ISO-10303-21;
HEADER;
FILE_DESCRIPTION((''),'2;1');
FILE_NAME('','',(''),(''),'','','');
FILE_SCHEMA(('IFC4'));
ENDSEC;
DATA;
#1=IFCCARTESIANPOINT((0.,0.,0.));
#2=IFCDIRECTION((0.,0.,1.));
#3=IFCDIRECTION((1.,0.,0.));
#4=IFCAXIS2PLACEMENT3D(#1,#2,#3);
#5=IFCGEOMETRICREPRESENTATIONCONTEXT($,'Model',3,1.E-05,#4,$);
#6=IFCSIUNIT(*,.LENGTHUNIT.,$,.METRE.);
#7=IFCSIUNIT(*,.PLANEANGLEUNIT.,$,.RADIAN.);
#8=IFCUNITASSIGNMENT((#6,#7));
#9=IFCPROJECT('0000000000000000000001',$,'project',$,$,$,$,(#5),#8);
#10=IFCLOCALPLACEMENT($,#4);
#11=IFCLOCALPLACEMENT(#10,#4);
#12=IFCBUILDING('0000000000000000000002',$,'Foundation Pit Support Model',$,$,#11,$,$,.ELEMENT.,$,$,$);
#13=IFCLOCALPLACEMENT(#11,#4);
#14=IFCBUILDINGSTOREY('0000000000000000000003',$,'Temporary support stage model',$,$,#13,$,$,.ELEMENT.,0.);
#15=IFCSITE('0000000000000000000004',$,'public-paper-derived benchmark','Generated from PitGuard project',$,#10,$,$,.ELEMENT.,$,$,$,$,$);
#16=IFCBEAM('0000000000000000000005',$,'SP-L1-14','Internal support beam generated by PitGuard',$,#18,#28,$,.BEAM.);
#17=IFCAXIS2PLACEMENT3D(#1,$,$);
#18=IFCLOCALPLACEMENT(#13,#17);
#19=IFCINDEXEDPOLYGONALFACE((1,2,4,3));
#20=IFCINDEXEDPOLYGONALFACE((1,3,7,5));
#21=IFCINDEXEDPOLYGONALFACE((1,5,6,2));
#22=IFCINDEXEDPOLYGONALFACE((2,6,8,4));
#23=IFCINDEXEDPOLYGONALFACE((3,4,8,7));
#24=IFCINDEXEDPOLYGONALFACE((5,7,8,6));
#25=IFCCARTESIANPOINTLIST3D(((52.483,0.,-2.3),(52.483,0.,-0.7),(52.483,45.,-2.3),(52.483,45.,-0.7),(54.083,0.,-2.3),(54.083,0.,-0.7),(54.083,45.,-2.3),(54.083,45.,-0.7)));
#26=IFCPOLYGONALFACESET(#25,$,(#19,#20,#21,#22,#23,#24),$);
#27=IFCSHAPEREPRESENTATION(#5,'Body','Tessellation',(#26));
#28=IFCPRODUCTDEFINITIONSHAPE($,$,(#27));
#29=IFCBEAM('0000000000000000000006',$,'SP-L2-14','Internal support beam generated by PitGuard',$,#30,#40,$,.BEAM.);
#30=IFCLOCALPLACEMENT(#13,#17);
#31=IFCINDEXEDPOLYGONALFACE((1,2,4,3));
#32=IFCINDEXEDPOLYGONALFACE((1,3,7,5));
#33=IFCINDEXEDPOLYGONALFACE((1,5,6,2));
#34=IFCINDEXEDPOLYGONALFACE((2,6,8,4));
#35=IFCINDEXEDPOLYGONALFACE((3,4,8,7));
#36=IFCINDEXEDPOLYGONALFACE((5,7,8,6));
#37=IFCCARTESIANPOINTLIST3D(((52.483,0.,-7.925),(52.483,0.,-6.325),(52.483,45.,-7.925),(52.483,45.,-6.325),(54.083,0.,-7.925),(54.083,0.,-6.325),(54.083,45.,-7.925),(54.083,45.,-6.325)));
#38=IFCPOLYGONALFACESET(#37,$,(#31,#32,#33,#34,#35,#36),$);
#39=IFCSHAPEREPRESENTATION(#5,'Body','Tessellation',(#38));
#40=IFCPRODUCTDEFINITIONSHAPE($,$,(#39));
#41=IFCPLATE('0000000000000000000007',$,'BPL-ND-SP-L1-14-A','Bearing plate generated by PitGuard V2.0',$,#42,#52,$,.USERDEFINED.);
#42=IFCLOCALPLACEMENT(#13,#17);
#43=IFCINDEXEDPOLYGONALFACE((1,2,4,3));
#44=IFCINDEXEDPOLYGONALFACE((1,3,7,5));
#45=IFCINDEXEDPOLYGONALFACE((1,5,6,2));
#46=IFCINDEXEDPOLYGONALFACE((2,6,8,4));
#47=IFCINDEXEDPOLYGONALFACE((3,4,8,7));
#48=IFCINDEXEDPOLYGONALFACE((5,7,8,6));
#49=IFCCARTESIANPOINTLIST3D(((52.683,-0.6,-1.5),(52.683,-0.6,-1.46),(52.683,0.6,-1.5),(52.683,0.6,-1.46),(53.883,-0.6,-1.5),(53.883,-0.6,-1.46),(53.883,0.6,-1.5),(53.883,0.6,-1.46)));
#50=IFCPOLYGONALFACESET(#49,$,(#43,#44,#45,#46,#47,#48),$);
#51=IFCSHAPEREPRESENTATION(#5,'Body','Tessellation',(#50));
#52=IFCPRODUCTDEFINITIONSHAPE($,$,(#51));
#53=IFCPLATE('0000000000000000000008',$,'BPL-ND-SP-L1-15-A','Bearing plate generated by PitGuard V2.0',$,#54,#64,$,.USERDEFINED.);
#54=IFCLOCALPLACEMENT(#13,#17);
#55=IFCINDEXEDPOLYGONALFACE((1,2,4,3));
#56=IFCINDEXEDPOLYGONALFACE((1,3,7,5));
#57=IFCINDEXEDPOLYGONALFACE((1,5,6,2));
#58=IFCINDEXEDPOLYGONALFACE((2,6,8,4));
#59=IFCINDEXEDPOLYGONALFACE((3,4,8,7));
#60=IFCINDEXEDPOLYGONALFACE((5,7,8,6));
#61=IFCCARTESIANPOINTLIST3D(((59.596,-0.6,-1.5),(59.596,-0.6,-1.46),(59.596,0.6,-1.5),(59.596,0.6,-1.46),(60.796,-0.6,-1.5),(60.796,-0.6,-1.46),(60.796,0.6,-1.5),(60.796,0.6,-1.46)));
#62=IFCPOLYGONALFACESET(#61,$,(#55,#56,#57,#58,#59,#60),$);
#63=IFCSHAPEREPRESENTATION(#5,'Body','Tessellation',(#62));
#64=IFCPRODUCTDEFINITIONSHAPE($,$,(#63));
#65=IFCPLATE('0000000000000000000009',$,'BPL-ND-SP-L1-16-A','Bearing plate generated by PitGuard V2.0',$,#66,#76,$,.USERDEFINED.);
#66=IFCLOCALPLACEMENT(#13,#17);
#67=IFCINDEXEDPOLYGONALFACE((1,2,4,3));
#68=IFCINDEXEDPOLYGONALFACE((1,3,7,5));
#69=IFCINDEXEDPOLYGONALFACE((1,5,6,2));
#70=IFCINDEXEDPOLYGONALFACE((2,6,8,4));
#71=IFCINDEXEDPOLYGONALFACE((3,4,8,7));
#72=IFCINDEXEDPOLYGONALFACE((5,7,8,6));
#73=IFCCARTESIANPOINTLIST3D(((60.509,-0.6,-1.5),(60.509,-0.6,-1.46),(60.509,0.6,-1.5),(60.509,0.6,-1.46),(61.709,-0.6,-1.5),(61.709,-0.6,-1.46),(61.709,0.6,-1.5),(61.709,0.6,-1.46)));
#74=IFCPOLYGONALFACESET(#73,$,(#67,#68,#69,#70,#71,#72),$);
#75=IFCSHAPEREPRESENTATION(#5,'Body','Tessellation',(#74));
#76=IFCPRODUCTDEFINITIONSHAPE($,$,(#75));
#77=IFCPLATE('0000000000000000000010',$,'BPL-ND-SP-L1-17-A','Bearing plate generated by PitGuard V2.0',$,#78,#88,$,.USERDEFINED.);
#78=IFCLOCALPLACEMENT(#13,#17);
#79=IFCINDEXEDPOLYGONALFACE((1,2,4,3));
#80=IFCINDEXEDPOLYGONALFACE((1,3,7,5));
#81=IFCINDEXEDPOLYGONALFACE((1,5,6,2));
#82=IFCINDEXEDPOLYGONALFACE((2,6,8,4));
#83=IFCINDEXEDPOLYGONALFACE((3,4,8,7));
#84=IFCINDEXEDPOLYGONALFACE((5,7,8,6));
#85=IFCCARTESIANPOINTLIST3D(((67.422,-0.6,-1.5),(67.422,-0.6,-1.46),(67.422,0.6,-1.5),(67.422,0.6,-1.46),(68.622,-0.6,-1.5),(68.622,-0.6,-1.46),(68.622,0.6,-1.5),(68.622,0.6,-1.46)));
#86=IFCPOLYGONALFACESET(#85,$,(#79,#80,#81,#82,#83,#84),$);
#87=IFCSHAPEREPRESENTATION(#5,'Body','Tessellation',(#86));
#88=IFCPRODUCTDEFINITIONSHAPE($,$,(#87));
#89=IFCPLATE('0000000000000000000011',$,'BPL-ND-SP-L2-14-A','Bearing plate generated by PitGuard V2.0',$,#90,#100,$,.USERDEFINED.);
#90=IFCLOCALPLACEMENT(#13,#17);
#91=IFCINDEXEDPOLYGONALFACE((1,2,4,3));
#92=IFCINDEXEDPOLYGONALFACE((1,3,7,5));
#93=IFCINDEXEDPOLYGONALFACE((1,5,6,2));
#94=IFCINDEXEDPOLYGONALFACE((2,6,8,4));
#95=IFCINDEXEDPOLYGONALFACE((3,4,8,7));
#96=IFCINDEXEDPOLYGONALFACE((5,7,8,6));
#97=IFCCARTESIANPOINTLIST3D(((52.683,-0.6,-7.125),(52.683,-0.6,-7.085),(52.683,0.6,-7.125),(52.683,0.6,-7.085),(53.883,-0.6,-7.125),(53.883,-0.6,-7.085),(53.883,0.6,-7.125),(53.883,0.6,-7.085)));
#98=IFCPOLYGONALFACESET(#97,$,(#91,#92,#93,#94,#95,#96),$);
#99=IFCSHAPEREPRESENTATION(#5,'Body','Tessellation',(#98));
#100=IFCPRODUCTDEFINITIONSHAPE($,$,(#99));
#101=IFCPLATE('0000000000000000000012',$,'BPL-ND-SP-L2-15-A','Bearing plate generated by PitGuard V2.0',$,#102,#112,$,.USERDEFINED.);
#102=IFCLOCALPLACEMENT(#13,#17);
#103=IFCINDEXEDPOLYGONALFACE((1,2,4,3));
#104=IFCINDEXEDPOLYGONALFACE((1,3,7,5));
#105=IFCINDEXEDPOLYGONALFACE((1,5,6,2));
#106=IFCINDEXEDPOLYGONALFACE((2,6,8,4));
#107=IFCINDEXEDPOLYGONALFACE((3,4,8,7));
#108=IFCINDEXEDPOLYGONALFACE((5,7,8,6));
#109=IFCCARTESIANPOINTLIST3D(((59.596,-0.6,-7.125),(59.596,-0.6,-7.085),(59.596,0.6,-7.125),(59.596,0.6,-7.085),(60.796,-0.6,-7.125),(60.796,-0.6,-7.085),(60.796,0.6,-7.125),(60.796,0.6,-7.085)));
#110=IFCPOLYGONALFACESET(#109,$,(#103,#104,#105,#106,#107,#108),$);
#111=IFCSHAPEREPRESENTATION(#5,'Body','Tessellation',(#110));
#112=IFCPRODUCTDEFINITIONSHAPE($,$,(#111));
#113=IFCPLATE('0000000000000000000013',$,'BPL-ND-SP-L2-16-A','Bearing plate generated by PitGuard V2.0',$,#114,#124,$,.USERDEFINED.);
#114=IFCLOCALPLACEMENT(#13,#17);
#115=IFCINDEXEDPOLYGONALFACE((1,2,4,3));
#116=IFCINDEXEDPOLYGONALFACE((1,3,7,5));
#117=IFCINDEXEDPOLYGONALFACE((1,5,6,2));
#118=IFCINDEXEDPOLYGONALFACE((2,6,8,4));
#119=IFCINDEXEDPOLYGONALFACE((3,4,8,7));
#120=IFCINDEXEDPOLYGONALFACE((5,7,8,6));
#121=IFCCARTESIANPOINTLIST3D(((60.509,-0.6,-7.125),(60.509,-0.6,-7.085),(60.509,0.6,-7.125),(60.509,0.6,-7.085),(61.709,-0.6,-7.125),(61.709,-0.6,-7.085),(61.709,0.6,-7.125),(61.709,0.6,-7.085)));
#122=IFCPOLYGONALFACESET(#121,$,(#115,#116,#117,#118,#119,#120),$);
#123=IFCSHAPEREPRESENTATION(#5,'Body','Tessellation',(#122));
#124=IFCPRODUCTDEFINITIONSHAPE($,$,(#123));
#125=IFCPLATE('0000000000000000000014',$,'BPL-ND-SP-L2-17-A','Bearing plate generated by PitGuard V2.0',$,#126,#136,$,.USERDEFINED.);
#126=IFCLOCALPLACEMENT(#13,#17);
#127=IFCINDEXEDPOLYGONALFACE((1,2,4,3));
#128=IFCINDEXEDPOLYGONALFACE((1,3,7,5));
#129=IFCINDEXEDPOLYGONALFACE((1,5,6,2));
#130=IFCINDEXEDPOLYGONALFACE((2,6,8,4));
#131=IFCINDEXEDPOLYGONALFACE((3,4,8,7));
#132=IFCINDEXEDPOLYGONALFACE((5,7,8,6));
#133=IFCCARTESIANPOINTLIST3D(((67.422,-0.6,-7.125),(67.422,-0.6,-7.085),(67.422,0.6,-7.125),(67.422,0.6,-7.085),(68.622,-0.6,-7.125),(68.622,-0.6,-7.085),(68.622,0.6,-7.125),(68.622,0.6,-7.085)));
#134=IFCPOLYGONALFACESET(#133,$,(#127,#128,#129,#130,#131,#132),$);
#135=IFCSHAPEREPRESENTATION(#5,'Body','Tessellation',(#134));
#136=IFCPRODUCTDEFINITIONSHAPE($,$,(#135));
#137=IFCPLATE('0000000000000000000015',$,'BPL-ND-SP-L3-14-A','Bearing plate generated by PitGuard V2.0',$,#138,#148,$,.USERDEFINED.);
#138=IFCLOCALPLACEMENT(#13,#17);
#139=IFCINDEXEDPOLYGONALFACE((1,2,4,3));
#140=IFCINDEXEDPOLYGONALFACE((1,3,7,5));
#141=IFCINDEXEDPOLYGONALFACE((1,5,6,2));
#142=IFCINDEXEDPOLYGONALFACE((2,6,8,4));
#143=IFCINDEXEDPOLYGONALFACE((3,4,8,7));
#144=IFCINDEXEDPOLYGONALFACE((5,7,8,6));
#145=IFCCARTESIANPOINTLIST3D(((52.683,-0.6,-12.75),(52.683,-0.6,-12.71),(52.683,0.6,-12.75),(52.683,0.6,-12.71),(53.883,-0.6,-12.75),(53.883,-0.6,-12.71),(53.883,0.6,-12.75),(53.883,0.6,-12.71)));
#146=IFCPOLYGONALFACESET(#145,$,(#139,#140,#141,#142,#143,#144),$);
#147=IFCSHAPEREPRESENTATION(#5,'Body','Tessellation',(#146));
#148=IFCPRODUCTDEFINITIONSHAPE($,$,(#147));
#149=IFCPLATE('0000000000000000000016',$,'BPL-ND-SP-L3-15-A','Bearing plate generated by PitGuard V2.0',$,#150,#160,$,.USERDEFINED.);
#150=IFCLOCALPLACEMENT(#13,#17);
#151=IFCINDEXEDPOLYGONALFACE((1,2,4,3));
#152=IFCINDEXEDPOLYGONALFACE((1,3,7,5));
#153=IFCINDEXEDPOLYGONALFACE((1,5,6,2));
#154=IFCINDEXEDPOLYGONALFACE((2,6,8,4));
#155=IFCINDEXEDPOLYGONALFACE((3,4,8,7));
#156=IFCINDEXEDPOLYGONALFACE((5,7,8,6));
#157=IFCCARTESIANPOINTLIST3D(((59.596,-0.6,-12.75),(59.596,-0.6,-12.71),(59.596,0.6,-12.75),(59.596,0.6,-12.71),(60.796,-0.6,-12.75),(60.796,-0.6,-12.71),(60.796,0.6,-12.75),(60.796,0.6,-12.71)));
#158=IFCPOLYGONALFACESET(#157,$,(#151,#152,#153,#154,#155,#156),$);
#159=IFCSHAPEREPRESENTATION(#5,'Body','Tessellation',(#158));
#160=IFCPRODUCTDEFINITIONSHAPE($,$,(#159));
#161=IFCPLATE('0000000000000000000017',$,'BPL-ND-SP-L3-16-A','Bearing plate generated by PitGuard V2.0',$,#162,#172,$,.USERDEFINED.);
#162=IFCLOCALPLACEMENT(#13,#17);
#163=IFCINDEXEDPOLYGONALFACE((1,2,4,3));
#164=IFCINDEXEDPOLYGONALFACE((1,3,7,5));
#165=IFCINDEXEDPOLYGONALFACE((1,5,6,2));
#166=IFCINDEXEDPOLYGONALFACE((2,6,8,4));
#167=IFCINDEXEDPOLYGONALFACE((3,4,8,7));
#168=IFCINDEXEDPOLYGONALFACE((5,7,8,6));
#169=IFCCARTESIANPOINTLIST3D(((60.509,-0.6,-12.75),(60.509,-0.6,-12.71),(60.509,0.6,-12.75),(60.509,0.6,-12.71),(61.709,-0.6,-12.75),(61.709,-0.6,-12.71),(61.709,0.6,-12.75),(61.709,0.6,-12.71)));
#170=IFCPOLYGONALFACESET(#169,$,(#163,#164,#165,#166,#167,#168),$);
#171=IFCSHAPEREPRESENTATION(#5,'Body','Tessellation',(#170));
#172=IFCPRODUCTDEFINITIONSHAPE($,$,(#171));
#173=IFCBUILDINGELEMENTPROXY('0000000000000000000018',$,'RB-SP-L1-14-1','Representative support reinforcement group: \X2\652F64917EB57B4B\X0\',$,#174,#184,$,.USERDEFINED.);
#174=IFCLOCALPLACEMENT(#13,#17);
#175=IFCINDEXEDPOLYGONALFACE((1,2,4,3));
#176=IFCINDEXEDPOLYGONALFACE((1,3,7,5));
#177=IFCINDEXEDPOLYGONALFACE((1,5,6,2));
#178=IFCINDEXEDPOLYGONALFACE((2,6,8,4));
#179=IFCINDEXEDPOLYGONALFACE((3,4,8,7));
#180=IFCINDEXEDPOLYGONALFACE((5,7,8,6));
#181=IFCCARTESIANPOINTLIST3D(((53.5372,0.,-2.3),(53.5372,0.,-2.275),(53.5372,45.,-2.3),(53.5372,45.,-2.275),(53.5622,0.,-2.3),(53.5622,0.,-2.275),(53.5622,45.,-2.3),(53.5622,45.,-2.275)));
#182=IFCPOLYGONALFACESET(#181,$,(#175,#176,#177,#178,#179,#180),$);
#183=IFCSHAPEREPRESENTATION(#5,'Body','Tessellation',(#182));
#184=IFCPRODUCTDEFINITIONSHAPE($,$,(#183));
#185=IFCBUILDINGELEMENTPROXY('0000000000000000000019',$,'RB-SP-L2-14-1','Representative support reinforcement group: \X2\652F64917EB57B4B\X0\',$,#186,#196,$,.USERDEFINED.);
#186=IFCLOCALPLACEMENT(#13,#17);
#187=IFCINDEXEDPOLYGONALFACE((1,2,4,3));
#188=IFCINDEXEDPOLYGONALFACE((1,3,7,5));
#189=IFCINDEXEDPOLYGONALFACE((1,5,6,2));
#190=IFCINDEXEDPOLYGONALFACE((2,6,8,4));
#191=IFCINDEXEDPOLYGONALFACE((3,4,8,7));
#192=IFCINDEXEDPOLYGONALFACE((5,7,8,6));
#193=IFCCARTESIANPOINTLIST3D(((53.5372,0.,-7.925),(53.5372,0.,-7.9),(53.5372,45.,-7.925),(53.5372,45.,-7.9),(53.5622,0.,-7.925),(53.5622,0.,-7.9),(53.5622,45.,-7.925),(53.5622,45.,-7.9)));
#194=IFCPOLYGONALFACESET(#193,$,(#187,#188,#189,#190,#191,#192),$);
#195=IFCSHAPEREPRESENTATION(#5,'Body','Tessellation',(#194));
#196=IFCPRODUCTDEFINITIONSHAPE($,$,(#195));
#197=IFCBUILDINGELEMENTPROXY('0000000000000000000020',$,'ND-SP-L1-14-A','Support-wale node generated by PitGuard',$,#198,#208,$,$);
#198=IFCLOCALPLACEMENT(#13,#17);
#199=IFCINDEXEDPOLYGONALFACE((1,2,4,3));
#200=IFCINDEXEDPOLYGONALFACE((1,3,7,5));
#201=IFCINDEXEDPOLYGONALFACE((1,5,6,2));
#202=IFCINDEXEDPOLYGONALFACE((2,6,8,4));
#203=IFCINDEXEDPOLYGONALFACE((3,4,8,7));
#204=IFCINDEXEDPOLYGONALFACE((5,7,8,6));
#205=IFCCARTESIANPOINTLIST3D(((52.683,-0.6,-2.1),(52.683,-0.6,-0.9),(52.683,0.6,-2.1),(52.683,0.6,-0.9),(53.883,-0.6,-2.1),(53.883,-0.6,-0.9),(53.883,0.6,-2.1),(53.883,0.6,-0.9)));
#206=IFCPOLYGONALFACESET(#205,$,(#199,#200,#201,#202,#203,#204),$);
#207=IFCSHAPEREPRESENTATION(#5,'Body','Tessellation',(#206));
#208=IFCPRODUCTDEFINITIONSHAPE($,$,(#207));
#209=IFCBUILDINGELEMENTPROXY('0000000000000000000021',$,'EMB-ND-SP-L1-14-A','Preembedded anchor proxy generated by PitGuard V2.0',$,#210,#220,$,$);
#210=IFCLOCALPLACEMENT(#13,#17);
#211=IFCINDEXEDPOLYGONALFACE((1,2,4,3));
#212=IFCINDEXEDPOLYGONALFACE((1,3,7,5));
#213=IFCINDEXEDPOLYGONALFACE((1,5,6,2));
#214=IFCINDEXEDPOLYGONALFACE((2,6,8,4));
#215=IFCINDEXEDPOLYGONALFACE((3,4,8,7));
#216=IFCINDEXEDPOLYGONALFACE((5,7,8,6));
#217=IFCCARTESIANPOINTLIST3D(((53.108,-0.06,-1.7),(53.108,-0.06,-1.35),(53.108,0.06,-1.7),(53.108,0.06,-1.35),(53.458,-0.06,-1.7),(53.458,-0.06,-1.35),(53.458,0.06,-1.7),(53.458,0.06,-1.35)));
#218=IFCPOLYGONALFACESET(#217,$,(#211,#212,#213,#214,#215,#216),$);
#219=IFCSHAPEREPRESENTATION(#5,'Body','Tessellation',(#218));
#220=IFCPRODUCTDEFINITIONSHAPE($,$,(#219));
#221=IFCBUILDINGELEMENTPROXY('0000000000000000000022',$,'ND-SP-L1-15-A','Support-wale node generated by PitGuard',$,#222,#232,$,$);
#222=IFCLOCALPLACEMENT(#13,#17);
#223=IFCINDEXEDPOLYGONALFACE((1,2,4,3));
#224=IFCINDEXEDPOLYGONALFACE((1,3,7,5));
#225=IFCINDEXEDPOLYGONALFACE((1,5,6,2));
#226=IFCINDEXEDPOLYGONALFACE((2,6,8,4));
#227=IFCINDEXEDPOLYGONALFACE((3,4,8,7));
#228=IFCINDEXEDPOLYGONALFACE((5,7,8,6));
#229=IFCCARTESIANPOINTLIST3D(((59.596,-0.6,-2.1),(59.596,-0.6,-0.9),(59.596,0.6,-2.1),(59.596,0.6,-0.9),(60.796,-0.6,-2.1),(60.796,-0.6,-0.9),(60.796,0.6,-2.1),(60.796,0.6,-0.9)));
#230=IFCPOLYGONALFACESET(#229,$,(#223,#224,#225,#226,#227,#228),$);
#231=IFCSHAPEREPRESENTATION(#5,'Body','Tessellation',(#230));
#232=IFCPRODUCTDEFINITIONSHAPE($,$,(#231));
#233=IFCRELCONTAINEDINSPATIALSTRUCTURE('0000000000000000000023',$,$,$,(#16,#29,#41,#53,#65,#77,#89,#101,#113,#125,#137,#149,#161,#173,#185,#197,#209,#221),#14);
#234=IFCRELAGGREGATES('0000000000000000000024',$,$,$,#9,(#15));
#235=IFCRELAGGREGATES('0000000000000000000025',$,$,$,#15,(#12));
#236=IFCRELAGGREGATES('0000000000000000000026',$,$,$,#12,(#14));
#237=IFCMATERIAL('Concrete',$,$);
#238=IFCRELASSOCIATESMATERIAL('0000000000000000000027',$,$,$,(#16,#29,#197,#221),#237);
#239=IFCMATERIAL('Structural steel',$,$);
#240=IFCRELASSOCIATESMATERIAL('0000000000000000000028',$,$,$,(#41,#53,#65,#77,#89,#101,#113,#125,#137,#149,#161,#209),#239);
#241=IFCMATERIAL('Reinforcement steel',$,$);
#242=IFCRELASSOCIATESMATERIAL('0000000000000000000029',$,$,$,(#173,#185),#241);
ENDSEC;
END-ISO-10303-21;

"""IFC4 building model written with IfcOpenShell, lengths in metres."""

from ifc_helpers import new_model, si_unit, frame, origin_with_axes, origin_2d, place, context, project, spatial, rectangle, extrude, material, element, save


model = new_model("IFC4")

# Units and contexts
model_context = context("Model", 3, precision=1e-05, world=origin_with_axes())
ifc_project = project(units=[si_unit("LENGTHUNIT", "METRE"), si_unit("PLANEANGLEUNIT", "RADIAN")], contexts=[model_context])

# Site, building, storey
site_placement = place(None, origin_with_axes())
site = spatial("IfcSite", under=ifc_project, at=site_placement, Name="public-paper-derived benchmark", Description="Generated from PitGuard project", CompositionType="ELEMENT")
building_placement = place(site_placement, origin_with_axes())
building = spatial("IfcBuilding", under=site, at=building_placement, Name="Foundation Pit Support Model", CompositionType="ELEMENT")
storey_placement = place(building_placement, origin_with_axes())
storey = spatial("IfcBuildingStorey", under=building, at=storey_placement, Name="Temporary support stage model", CompositionType="ELEMENT", Elevation=0.0)

# Beams
ifc_material_1 = material(Name="Concrete")
for number, where, z_axis, x_axis, name in (
    (1, (53.283, 22.5, -2.3), (0.0, 0.0, 1.0), (0.0, 1.0, 0.0), "SP-L1-14"),
    (2, (53.283, 22.5, -7.925), (0.0, 0.0, 1.0), (0.0, 1.0, 0.0), "SP-L2-14"),
):
    element("IfcBeam", number, at=place(storey_placement, frame(where, z_axis=z_axis, x_axis=x_axis)), inside=storey, material=ifc_material_1, Name=name, Description="Internal support beam generated by PitGuard", PredefinedType="BEAM", context=model_context, shape_type="SweptSolid", body=[
        extrude(rectangle(XDim=45.0, YDim=1.6, at=origin_2d()), origin_with_axes(), (0.0, 0.0, 1.0), 1.6),
    ])

# Plates
ifc_material_2 = material(Name="Structural steel")
for number, where, z_axis, x_axis, name in (
    (3, (53.283, 0.0, -1.5), (0.0, 0.0, 1.0), (1.0, 0.0, 0.0), "BPL-ND-SP-L1-14-A"),
    (4, (60.196, 0.0, -1.5), (0.0, 0.0, 1.0), (1.0, 0.0, 0.0), "BPL-ND-SP-L1-15-A"),
    (5, (61.109, 0.0, -1.5), (0.0, 0.0, 1.0), (1.0, 0.0, 0.0), "BPL-ND-SP-L1-16-A"),
    (6, (68.022, 0.0, -1.5), (0.0, 0.0, 1.0), (1.0, 0.0, 0.0), "BPL-ND-SP-L1-17-A"),
    (7, (53.283, 0.0, -7.125), (0.0, 0.0, 1.0), (1.0, 0.0, 0.0), "BPL-ND-SP-L2-14-A"),
    (8, (60.196, 0.0, -7.125), (0.0, 0.0, 1.0), (1.0, 0.0, 0.0), "BPL-ND-SP-L2-15-A"),
    (9, (61.109, 0.0, -7.125), (0.0, 0.0, 1.0), (1.0, 0.0, 0.0), "BPL-ND-SP-L2-16-A"),
    (10, (68.022, 0.0, -7.125), (0.0, 0.0, 1.0), (1.0, 0.0, 0.0), "BPL-ND-SP-L2-17-A"),
    (11, (53.283, 0.0, -12.75), (0.0, 0.0, 1.0), (1.0, 0.0, 0.0), "BPL-ND-SP-L3-14-A"),
    (12, (60.196, 0.0, -12.75), (0.0, 0.0, 1.0), (1.0, 0.0, 0.0), "BPL-ND-SP-L3-15-A"),
    (13, (61.109, 0.0, -12.75), (0.0, 0.0, 1.0), (1.0, 0.0, 0.0), "BPL-ND-SP-L3-16-A"),
):
    element("IfcPlate", number, at=place(storey_placement, frame(where, z_axis=z_axis, x_axis=x_axis)), inside=storey, material=ifc_material_2, Name=name, Description="Bearing plate generated by PitGuard V2.0", PredefinedType="USERDEFINED", context=model_context, shape_type="SweptSolid", body=[
        extrude(rectangle(XDim=1.2, YDim=1.2, at=origin_2d()), origin_with_axes(), (0.0, 0.0, 1.0), 0.04),
    ])

# Building element proxies
ifc_material_3 = material(Name="Reinforcement steel")
for number, where, z_axis, x_axis, name in (
    (14, (53.5497, 22.5, -2.3), (0.0, 0.0, 1.0), (0.0, 1.0, 0.0), "RB-SP-L1-14-1"),
    (15, (53.5497, 22.5, -7.925), (0.0, 0.0, 1.0), (0.0, 1.0, 0.0), "RB-SP-L2-14-1"),
):
    element("IfcBuildingElementProxy", number, at=place(storey_placement, frame(where, z_axis=z_axis, x_axis=x_axis)), inside=storey, material=ifc_material_3, Name=name, Description="Representative support reinforcement group: 支撑纵筋", PredefinedType="USERDEFINED", context=model_context, shape_type="SweptSolid", body=[
        extrude(rectangle(XDim=45.0, YDim=0.025, at=origin_2d()), origin_with_axes(), (0.0, 0.0, 1.0), 0.025),
    ])
proxy_1_placement = place(storey_placement, frame((53.283, 0.0, -2.1), z_axis=(0.0, 0.0, 1.0), x_axis=(1.0, 0.0, 0.0)))
element("IfcBuildingElementProxy", 16, at=proxy_1_placement, inside=storey, material=ifc_material_1, Name="ND-SP-L1-14-A", Description="Support-wale node generated by PitGuard", context=model_context, shape_type="SweptSolid", body=[
    extrude(rectangle(XDim=1.2, YDim=1.2, at=origin_2d()), origin_with_axes(), (0.0, 0.0, 1.0), 1.2),
])
proxy_2_placement = place(storey_placement, frame((53.283, 0.0, -1.7), z_axis=(0.0, 0.0, 1.0), x_axis=(1.0, 0.0, 0.0)))
element("IfcBuildingElementProxy", 17, at=proxy_2_placement, inside=storey, material=ifc_material_2, Name="EMB-ND-SP-L1-14-A", Description="Preembedded anchor proxy generated by PitGuard V2.0", context=model_context, shape_type="SweptSolid", body=[
    extrude(rectangle(XDim=0.35, YDim=0.12, at=origin_2d()), origin_with_axes(), (0.0, 0.0, 1.0), 0.35),
])
proxy_3_placement = place(storey_placement, frame((60.196, 0.0, -2.1), z_axis=(0.0, 0.0, 1.0), x_axis=(1.0, 0.0, 0.0)))
element("IfcBuildingElementProxy", 18, at=proxy_3_placement, inside=storey, material=ifc_material_1, Name="ND-SP-L1-15-A", Description="Support-wale node generated by PitGuard", context=model_context, shape_type="SweptSolid", body=[
    extrude(rectangle(XDim=1.2, YDim=1.2, at=origin_2d()), origin_with_axes(), (0.0, 0.0, 1.0), 1.2),
])

save(model, "model.ifc")
